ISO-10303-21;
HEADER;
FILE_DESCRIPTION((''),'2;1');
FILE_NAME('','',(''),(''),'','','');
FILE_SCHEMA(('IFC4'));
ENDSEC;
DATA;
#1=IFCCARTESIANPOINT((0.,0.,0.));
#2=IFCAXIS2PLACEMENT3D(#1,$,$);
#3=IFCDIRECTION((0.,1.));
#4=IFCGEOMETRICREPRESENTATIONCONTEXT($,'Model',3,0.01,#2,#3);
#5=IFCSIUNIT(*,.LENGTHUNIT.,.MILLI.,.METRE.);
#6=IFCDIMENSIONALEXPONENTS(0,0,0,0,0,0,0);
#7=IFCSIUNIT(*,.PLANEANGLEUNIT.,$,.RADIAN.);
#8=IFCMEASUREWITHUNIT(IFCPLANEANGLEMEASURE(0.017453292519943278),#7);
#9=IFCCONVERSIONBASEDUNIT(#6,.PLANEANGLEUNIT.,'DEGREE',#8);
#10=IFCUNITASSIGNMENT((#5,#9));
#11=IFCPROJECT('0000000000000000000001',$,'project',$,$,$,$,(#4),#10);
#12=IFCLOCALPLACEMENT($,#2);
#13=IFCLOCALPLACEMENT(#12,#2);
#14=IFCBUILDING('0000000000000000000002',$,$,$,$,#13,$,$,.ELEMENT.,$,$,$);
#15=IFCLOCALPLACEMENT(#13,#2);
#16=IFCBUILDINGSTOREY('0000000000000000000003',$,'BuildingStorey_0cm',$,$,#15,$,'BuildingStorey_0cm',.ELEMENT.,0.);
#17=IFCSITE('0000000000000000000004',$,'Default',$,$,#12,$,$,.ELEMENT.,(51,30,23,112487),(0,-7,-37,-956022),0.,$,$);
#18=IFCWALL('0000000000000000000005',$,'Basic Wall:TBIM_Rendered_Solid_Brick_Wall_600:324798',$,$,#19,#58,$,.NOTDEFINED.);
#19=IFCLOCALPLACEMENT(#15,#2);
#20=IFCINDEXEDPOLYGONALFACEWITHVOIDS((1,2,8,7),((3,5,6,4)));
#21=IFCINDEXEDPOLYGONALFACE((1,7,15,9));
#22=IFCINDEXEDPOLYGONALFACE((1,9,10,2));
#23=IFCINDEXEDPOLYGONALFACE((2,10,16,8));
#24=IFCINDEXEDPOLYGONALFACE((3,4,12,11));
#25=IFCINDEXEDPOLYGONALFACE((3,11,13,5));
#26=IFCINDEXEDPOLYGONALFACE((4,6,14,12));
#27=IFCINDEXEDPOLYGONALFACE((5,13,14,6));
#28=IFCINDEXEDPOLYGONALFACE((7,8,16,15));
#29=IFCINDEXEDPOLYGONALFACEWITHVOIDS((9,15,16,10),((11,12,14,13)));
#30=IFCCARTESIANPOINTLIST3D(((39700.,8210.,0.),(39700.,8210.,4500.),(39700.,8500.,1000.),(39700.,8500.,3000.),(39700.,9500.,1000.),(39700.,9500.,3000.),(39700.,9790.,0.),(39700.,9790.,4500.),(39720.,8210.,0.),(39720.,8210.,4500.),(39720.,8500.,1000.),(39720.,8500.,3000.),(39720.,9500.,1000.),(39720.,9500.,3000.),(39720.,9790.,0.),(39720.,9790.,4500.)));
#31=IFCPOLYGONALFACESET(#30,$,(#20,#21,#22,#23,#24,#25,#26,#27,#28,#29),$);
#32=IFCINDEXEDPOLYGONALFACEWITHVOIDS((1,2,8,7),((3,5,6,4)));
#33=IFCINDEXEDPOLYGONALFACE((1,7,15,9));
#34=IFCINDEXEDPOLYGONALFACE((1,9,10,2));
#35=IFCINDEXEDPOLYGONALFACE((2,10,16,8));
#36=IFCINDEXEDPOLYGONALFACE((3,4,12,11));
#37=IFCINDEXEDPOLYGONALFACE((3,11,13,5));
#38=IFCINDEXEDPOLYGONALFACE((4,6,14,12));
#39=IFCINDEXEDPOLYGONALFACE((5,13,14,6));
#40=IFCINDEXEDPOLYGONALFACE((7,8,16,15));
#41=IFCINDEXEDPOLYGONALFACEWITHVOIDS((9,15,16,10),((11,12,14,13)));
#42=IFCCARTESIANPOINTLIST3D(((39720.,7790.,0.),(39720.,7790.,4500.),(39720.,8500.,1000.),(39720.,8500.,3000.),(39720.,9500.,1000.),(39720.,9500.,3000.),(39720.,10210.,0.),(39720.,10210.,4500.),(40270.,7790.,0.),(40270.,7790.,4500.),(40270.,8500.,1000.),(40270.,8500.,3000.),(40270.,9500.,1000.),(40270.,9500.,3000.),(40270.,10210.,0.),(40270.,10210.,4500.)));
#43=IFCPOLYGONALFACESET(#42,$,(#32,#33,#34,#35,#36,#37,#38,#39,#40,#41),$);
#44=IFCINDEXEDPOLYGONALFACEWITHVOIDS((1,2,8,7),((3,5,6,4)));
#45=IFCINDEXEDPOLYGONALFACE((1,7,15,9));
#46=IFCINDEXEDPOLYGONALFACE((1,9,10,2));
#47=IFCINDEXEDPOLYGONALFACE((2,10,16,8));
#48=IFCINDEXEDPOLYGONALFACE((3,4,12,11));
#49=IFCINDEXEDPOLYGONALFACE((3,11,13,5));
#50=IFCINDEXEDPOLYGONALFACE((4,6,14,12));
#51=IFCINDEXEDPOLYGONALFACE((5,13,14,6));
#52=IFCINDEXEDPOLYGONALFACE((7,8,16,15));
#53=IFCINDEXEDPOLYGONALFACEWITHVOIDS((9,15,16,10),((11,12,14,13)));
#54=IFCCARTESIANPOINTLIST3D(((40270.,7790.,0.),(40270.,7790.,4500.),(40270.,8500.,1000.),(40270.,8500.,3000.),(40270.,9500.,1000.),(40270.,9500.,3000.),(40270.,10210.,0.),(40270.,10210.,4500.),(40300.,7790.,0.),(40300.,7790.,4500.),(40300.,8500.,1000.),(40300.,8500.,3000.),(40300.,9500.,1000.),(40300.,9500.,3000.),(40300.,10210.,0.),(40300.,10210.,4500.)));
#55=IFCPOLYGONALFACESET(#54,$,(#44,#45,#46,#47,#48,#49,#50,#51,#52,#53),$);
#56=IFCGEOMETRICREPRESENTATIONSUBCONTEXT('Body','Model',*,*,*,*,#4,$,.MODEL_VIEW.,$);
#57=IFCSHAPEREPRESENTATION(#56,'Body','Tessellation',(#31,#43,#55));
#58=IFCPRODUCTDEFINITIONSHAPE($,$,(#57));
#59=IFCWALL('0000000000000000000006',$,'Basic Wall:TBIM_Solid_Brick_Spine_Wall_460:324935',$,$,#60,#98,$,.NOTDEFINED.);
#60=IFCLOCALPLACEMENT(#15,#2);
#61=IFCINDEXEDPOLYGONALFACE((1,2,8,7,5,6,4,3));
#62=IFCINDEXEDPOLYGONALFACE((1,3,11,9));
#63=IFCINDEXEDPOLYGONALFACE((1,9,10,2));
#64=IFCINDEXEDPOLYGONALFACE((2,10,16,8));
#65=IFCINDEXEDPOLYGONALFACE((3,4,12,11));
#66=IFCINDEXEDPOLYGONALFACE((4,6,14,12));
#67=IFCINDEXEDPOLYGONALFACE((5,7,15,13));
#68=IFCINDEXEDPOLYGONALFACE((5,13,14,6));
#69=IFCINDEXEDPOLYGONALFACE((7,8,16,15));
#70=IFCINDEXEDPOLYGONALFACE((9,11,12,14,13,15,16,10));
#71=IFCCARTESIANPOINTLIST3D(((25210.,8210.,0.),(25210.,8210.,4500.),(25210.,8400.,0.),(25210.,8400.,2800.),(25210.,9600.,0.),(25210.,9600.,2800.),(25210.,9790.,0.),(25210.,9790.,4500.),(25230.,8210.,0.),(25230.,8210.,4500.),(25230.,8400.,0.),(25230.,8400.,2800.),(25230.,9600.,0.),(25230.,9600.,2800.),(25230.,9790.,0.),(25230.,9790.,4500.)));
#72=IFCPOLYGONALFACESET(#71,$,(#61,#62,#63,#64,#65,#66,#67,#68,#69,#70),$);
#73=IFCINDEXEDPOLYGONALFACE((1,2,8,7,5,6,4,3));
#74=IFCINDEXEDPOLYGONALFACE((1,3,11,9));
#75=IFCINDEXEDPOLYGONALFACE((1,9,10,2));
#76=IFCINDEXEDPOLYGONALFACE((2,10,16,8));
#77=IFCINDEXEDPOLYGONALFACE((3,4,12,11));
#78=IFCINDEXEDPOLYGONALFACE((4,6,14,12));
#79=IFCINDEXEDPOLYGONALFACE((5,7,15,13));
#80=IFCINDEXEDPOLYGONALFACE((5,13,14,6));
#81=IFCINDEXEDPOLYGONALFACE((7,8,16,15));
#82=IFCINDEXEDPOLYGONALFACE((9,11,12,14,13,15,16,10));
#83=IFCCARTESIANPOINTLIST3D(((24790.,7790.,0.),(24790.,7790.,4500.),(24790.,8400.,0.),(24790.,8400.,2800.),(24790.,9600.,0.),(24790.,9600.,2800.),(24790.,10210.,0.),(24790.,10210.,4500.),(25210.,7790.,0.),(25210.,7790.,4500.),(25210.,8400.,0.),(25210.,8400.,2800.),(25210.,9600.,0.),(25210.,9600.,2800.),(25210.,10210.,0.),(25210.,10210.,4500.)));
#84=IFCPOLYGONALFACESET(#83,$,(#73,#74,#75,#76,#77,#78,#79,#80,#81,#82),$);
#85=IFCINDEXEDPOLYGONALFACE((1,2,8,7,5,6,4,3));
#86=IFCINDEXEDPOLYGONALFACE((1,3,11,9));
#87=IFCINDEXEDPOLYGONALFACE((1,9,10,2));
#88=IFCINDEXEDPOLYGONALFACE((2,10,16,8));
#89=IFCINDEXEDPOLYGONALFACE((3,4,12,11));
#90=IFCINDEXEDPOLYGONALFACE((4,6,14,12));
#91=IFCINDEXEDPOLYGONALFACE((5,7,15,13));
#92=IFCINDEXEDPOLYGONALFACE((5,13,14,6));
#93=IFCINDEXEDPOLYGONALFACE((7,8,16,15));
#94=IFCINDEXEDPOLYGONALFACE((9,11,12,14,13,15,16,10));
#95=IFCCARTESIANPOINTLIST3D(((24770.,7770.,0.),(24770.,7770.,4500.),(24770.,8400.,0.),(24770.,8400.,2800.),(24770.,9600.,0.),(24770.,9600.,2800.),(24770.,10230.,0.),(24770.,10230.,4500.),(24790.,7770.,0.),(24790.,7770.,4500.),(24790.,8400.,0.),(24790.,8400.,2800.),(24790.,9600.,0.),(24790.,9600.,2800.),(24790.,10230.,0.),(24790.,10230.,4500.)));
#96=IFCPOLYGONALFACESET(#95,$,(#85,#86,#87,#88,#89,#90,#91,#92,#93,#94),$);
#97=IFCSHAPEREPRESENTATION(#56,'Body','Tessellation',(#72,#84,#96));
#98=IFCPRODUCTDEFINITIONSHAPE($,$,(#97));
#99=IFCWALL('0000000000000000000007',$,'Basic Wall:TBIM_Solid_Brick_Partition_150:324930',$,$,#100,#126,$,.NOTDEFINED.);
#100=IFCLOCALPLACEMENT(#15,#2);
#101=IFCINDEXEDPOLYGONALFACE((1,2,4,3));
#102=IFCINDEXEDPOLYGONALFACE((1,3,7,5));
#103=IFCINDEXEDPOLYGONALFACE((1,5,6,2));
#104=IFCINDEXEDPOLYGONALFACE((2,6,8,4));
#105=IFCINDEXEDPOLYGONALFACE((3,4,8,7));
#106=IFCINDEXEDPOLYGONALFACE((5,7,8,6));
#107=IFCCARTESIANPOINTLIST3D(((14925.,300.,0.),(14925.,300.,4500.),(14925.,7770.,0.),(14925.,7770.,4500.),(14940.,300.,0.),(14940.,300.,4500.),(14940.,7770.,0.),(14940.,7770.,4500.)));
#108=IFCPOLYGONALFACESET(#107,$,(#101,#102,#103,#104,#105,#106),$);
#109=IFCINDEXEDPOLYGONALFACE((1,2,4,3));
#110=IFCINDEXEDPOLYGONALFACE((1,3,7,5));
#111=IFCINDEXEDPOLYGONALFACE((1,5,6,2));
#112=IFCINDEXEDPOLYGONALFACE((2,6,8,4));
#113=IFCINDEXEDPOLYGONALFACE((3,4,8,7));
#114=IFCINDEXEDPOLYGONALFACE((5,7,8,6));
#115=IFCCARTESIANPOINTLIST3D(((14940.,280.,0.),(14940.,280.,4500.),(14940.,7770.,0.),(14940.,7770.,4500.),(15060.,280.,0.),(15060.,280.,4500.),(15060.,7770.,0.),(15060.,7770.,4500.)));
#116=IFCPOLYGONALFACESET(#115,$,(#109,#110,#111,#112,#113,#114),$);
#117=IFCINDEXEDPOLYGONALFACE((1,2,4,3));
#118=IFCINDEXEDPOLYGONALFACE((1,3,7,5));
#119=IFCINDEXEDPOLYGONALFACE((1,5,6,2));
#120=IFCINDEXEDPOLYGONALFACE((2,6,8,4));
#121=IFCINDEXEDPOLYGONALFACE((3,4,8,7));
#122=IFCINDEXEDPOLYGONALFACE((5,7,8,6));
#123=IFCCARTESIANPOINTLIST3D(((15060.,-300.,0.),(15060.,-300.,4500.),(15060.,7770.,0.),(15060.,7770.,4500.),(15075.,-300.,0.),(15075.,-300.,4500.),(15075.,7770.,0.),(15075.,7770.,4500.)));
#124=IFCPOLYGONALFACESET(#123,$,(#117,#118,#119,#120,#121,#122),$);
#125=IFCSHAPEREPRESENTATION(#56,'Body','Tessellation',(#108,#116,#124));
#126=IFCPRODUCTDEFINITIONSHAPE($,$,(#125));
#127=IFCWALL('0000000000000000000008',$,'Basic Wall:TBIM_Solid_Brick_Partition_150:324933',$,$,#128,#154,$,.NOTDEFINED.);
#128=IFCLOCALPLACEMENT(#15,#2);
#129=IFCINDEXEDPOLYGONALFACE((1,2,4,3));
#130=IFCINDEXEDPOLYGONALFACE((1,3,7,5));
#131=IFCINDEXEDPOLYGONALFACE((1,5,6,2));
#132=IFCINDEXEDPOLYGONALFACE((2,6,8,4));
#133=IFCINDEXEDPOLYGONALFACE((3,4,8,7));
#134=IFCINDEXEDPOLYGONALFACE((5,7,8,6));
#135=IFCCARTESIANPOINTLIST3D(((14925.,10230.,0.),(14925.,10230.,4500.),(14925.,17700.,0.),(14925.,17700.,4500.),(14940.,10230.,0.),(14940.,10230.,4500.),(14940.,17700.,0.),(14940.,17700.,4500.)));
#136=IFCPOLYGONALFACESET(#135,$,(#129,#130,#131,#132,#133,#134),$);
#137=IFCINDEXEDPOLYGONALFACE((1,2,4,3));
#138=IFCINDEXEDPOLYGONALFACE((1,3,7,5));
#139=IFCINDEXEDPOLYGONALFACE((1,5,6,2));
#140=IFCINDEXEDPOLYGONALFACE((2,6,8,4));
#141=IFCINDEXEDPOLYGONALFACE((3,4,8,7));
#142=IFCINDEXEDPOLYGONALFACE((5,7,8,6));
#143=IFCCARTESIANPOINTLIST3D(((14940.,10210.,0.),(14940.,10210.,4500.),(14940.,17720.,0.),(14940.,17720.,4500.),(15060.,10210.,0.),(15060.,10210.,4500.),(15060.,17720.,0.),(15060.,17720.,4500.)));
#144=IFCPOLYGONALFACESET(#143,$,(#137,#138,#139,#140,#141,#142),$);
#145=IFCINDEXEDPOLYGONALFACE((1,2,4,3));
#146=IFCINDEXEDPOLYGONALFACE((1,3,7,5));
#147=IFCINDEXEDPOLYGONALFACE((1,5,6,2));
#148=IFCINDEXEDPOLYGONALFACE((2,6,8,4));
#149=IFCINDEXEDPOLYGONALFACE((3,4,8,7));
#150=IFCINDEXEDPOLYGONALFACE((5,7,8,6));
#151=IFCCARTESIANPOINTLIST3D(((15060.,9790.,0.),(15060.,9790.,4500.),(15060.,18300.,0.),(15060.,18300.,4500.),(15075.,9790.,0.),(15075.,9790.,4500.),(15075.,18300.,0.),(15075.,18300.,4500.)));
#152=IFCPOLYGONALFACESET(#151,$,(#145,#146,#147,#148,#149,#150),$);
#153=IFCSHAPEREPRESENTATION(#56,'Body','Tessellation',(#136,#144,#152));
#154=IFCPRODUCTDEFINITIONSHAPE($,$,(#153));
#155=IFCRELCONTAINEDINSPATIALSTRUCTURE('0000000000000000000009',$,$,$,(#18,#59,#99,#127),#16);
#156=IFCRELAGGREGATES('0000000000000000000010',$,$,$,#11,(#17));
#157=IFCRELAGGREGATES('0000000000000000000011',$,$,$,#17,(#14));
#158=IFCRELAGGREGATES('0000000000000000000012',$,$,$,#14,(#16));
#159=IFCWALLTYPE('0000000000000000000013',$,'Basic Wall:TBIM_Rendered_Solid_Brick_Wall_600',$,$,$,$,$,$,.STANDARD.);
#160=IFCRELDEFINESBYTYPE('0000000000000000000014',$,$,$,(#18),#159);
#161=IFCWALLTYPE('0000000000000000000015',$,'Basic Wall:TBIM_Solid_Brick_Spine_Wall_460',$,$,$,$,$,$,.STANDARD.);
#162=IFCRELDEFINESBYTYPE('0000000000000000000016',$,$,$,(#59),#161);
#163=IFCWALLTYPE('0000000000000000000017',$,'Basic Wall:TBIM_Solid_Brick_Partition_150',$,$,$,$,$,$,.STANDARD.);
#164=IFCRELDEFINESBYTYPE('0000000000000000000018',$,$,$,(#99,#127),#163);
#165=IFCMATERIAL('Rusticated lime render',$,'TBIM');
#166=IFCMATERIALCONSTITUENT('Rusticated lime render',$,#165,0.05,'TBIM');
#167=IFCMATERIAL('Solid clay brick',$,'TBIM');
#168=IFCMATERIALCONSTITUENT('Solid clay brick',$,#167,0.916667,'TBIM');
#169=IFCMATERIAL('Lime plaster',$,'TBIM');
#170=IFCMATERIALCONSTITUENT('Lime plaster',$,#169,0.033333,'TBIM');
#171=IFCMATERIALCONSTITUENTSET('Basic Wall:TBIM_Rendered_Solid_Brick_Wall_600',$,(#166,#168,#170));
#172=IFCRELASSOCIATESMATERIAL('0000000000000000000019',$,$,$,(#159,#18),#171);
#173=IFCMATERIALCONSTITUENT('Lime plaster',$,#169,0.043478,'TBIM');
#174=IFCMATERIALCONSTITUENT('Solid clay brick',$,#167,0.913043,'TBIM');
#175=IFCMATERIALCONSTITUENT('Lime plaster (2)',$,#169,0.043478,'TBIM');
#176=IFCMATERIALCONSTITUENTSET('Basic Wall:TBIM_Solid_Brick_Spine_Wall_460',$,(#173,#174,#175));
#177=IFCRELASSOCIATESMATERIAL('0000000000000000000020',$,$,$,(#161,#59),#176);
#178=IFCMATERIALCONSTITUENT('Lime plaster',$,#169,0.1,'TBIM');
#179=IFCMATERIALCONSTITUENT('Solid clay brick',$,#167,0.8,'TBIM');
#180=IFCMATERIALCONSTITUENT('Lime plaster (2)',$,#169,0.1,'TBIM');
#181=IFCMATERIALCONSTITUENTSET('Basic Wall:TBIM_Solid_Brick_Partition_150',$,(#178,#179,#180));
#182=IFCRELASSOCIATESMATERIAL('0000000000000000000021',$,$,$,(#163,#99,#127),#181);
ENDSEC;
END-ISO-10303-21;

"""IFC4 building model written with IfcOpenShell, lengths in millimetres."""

from ifc_helpers import new_model, entity, si_unit, converted_unit, direction, frame, origin, place, context, subcontext, project, spatial, indexed_curve, outline, extrude, material, constituent, constituent_set, type_object, element, save


model = new_model("IFC4")

# Units and contexts
model_context = context("Model", 3, precision=0.01, world=origin(), true_north=direction((0.0, 1.0)))
body_context = subcontext(model_context, "Body", "Model", "MODEL_VIEW")
ifc_project = project(units=[si_unit("LENGTHUNIT", "METRE", prefix="MILLI"), converted_unit("PLANEANGLEUNIT", "DEGREE", entity("IfcPlaneAngleMeasure", 0.017453292519943278), si_unit("PLANEANGLEUNIT", "RADIAN"), dimensions=[0, 0, 0, 0, 0, 0, 0])], contexts=[model_context])

# Site, building, storey
site_placement = place(None, origin())
site = spatial("IfcSite", under=ifc_project, at=site_placement, Name="Default", CompositionType="ELEMENT", RefLatitude=(51, 30, 23, 112487), RefLongitude=(0, -7, -37, -956022), RefElevation=0.0)
building_placement = place(site_placement, origin())
building = spatial("IfcBuilding", under=site, at=building_placement, CompositionType="ELEMENT")
storey_placement = place(building_placement, origin())
storey = spatial("IfcBuildingStorey", under=building, at=storey_placement, Name="BuildingStorey_0cm", LongName="BuildingStorey_0cm", CompositionType="ELEMENT", Elevation=0.0)

# Walls, openings
ifc_material_1 = material(Name="Rusticated lime render", Category="TBIM")
ifc_constituent_1 = constituent(ifc_material_1, Name="Rusticated lime render", Category="TBIM", fraction=0.05)
ifc_material_2 = material(Name="Solid clay brick", Category="TBIM")
ifc_constituent_2 = constituent(ifc_material_2, Name="Solid clay brick", Category="TBIM", fraction=0.916667)
ifc_material_3 = material(Name="Lime plaster", Category="TBIM")
ifc_constituent_3 = constituent(ifc_material_3, Name="Lime plaster", Category="TBIM", fraction=0.033333)
ifc_constituent_set_1 = constituent_set(constituents=[ifc_constituent_1, ifc_constituent_2, ifc_constituent_3], Name="Basic Wall:TBIM_Rendered_Solid_Brick_Wall_600")
wall_type_1 = type_object("IfcWallType", Name="Basic Wall:TBIM_Rendered_Solid_Brick_Wall_600", PredefinedType="STANDARD", material=ifc_constituent_set_1)
wall_1_placement = place(storey_placement, frame((40000.0, 10230.0, 0.0), z_axis=(0.0, 0.0, 1.0), x_axis=(0.0, -1.0, 0.0)))
wall_1 = element("IfcWall", 1, at=wall_1_placement, inside=storey, type_object=wall_type_1, material=ifc_constituent_set_1, Name="Basic Wall:TBIM_Rendered_Solid_Brick_Wall_600:324798", PredefinedType="NOTDEFINED", context=body_context, shape_type="SweptSolid", body=[
    extrude(outline(indexed_curve([(-2250.0, -790.0), (2250.0, -790.0), (2250.0, -770.0), (2250.0, 770.0), (2250.0, 790.0), (-2250.0, 790.0), (-2250.0, 770.0), (-2250.0, -770.0), (-2250.0, -790.0)], self_intersect=False), holes=[indexed_curve([(750.0, -500.0), (-1250.0, -500.0), (-1250.0, 500.0), (750.0, 500.0), (750.0, -500.0)], self_intersect=False)]), frame((1230.0, -300.0, 2250.0), z_axis=(0.0, 1.0, 0.0), x_axis=(0.0, 0.0, 1.0)), (0.0, 0.0, 1.0), 20.0),
    extrude(outline(indexed_curve([(-2250.0, -1210.0), (2250.0, -1210.0), (2250.0, 1210.0), (-2250.0, 1210.0), (-2250.0, -1210.0)], self_intersect=False), holes=[indexed_curve([(-1250.0, -500.0), (-1250.0, 500.0), (750.0, 500.0), (750.0, -500.0), (-1250.0, -500.0)], self_intersect=False)]), frame((1230.0, -280.0, 2250.0), z_axis=(0.0, 1.0, 0.0), x_axis=(0.0, 0.0, 1.0)), (0.0, 0.0, 1.0), 550.0),
    extrude(outline(indexed_curve([(-2250.0, -1210.0), (2250.0, -1210.0), (2250.0, 1210.0), (-2250.0, 1210.0), (-2250.0, -1210.0)], self_intersect=False), holes=[indexed_curve([(-1250.0, -500.0), (-1250.0, 500.0), (750.0, 500.0), (750.0, -500.0), (-1250.0, -500.0)], self_intersect=False)]), frame((1230.0, 270.0, 2250.0), z_axis=(0.0, 1.0, 0.0), x_axis=(0.0, 0.0, 1.0)), (0.0, 0.0, 1.0), 30.0),
])
opening_1_placement = place(wall_1_placement, frame((730.0, -300.0, 1000.0)))
element("IfcOpeningElement", 2, at=opening_1_placement, cuts=wall_1, PredefinedType="OPENING", context=body_context, shape_type="SweptSolid", body=[
    extrude(outline(indexed_curve([(2000.0, 0.0), (2000.0, 1000.0), (0.0, 1000.0), (0.0, 0.0), (2000.0, 0.0)], self_intersect=False)), frame((0.0, 0.0, 0.0), z_axis=(0.0, 1.0, 0.0), x_axis=(0.0, 0.0, 1.0)), (0.0, 0.0, 1.0), 600.0),
])
ifc_constituent_4 = constituent(ifc_material_3, Name="Lime plaster", Category="TBIM", fraction=0.043478)
ifc_constituent_5 = constituent(ifc_material_2, Name="Solid clay brick", Category="TBIM", fraction=0.913043)
ifc_constituent_6 = constituent(ifc_material_3, Name="Lime plaster (2)", Category="TBIM", fraction=0.043478)
ifc_constituent_set_2 = constituent_set(constituents=[ifc_constituent_4, ifc_constituent_5, ifc_constituent_6], Name="Basic Wall:TBIM_Solid_Brick_Spine_Wall_460")
wall_type_2 = type_object("IfcWallType", Name="Basic Wall:TBIM_Solid_Brick_Spine_Wall_460", PredefinedType="STANDARD", material=ifc_constituent_set_2)
wall_2_placement = place(storey_placement, frame((25000.0, 10230.0, 0.0), z_axis=(0.0, 0.0, 1.0), x_axis=(0.0, -1.0, 0.0)))
wall_2 = element("IfcWall", 3, at=wall_2_placement, inside=storey, type_object=wall_type_2, material=ifc_constituent_set_2, Name="Basic Wall:TBIM_Solid_Brick_Spine_Wall_460:324935", PredefinedType="NOTDEFINED", context=body_context, shape_type="SweptSolid", body=[
    extrude(outline(indexed_curve([(-1825.0, -790.0), (2675.0, -790.0), (2675.0, 790.0), (-1825.0, 790.0), (-1825.0, 600.0), (975.0, 600.0), (975.0, -600.0), (-1825.0, -600.0), (-1825.0, -790.0)], self_intersect=False)), frame((1230.0, 210.0, 1825.0), z_axis=(0.0, 1.0, 0.0), x_axis=(0.0, 0.0, 1.0)), (0.0, 0.0, 1.0), 20.0),
    extrude(outline(indexed_curve([(-1825.0, -1210.0), (2675.0, -1210.0), (2675.0, 1210.0), (-1825.0, 1210.0), (-1825.0, 600.0), (975.0, 600.0), (975.0, -600.0), (-1825.0, -600.0), (-1825.0, -1210.0)], self_intersect=False)), frame((1230.0, -210.0, 1825.0), z_axis=(0.0, 1.0, 0.0), x_axis=(0.0, 0.0, 1.0)), (0.0, 0.0, 1.0), 420.0),
    extrude(outline(indexed_curve([(-2675.0, -1230.0), (1825.0, -1230.0), (1825.0, -600.0), (-975.0, -600.0), (-975.0, 600.0), (1825.0, 600.0), (1825.0, 1230.0), (-2675.0, 1230.0), (-2675.0, -1230.0)], self_intersect=False)), frame((1230.0, -230.0, 1825.0), z_axis=(0.0, 1.0, 0.0), x_axis=(0.0, 0.0, -1.0)), (0.0, 0.0, 1.0), 20.0),
])
opening_2_placement = place(wall_2_placement, frame((630.0, -230.0, 0.0)))
element("IfcOpeningElement", 4, at=opening_2_placement, cuts=wall_2, PredefinedType="OPENING", context=body_context, shape_type="SweptSolid", body=[
    extrude(outline(indexed_curve([(0.0, 1200.0), (0.0, 0.0), (2800.0, 0.0), (2800.0, 1200.0), (0.0, 1200.0)], self_intersect=False)), frame((0.0, 0.0, 0.0), z_axis=(0.0, 1.0, 0.0), x_axis=(0.0, 0.0, 1.0)), (0.0, 0.0, 1.0), 460.0),
])

# Walls
ifc_constituent_7 = constituent(ifc_material_3, Name="Lime plaster", Category="TBIM", fraction=0.1)
ifc_constituent_8 = constituent(ifc_material_2, Name="Solid clay brick", Category="TBIM", fraction=0.8)
ifc_constituent_9 = constituent(ifc_material_3, Name="Lime plaster (2)", Category="TBIM", fraction=0.1)
ifc_constituent_set_3 = constituent_set(constituents=[ifc_constituent_7, ifc_constituent_8, ifc_constituent_9], Name="Basic Wall:TBIM_Solid_Brick_Partition_150")
wall_type_3 = type_object("IfcWallType", Name="Basic Wall:TBIM_Solid_Brick_Partition_150", PredefinedType="STANDARD", material=ifc_constituent_set_3)
wall_3_placement = place(storey_placement, frame((15000.0, 300.0, 0.0), z_axis=(0.0, 0.0, 1.0), x_axis=(0.0, 1.0, 0.0)))
element("IfcWall", 5, at=wall_3_placement, inside=storey, type_object=wall_type_3, material=ifc_constituent_set_3, Name="Basic Wall:TBIM_Solid_Brick_Partition_150:324930", PredefinedType="NOTDEFINED", context=body_context, shape_type="SweptSolid", body=[
    extrude(outline(indexed_curve([(-7.5, -3735.0), (7.5, -3735.0), (7.5, 3735.0), (-7.5, 3735.0), (-7.5, -3735.0)], self_intersect=False)), frame((3735.0, 67.5, 0.0), z_axis=(0.0, 0.0, 1.0), x_axis=(0.0, -1.0, 0.0)), (0.0, 0.0, 1.0), 4500.0),
    extrude(outline(indexed_curve([(-3745.0, -60.0), (3745.0, -60.0), (3745.0, 60.0), (-3745.0, 60.0), (-3745.0, -60.0)], self_intersect=False)), frame((3725.0, 0.0, 0.0)), (0.0, 0.0, 1.0), 4500.0),
    extrude(outline(indexed_curve([(-7.5, -4035.0), (7.5, -4035.0), (7.5, 4035.0), (-7.5, 4035.0), (-7.5, -4035.0)], self_intersect=False)), frame((3435.0, -67.5, 0.0), z_axis=(0.0, 0.0, 1.0), x_axis=(0.0, 1.0, 0.0)), (0.0, 0.0, 1.0), 4500.0),
])
wall_4_placement = place(storey_placement, frame((15000.0, 10230.0, 0.0), z_axis=(0.0, 0.0, 1.0), x_axis=(0.0, 1.0, 0.0)))
element("IfcWall", 6, at=wall_4_placement, inside=storey, type_object=wall_type_3, material=ifc_constituent_set_3, Name="Basic Wall:TBIM_Solid_Brick_Partition_150:324933", PredefinedType="NOTDEFINED", context=body_context, shape_type="SweptSolid", body=[
    extrude(outline(indexed_curve([(-7.5, -3735.0), (7.5, -3735.0), (7.5, 3735.0), (-7.5, 3735.0), (-7.5, -3735.0)], self_intersect=False)), frame((3735.0, 67.5, 0.0), z_axis=(0.0, 0.0, 1.0), x_axis=(0.0, -1.0, 0.0)), (0.0, 0.0, 1.0), 4500.0),
    extrude(outline(indexed_curve([(-3755.0, -60.0), (3755.0, -60.0), (3755.0, 60.0), (-3755.0, 60.0), (-3755.0, -60.0)], self_intersect=False)), frame((3735.0, 0.0, 0.0)), (0.0, 0.0, 1.0), 4500.0),
    extrude(outline(indexed_curve([(-7.5, -4255.0), (7.5, -4255.0), (7.5, 4255.0), (-7.5, 4255.0), (-7.5, -4255.0)], self_intersect=False)), frame((3815.0, -67.5, 0.0), z_axis=(0.0, 0.0, 1.0), x_axis=(0.0, 1.0, 0.0)), (0.0, 0.0, 1.0), 4500.0),
])

save(model, "model.ifc")
